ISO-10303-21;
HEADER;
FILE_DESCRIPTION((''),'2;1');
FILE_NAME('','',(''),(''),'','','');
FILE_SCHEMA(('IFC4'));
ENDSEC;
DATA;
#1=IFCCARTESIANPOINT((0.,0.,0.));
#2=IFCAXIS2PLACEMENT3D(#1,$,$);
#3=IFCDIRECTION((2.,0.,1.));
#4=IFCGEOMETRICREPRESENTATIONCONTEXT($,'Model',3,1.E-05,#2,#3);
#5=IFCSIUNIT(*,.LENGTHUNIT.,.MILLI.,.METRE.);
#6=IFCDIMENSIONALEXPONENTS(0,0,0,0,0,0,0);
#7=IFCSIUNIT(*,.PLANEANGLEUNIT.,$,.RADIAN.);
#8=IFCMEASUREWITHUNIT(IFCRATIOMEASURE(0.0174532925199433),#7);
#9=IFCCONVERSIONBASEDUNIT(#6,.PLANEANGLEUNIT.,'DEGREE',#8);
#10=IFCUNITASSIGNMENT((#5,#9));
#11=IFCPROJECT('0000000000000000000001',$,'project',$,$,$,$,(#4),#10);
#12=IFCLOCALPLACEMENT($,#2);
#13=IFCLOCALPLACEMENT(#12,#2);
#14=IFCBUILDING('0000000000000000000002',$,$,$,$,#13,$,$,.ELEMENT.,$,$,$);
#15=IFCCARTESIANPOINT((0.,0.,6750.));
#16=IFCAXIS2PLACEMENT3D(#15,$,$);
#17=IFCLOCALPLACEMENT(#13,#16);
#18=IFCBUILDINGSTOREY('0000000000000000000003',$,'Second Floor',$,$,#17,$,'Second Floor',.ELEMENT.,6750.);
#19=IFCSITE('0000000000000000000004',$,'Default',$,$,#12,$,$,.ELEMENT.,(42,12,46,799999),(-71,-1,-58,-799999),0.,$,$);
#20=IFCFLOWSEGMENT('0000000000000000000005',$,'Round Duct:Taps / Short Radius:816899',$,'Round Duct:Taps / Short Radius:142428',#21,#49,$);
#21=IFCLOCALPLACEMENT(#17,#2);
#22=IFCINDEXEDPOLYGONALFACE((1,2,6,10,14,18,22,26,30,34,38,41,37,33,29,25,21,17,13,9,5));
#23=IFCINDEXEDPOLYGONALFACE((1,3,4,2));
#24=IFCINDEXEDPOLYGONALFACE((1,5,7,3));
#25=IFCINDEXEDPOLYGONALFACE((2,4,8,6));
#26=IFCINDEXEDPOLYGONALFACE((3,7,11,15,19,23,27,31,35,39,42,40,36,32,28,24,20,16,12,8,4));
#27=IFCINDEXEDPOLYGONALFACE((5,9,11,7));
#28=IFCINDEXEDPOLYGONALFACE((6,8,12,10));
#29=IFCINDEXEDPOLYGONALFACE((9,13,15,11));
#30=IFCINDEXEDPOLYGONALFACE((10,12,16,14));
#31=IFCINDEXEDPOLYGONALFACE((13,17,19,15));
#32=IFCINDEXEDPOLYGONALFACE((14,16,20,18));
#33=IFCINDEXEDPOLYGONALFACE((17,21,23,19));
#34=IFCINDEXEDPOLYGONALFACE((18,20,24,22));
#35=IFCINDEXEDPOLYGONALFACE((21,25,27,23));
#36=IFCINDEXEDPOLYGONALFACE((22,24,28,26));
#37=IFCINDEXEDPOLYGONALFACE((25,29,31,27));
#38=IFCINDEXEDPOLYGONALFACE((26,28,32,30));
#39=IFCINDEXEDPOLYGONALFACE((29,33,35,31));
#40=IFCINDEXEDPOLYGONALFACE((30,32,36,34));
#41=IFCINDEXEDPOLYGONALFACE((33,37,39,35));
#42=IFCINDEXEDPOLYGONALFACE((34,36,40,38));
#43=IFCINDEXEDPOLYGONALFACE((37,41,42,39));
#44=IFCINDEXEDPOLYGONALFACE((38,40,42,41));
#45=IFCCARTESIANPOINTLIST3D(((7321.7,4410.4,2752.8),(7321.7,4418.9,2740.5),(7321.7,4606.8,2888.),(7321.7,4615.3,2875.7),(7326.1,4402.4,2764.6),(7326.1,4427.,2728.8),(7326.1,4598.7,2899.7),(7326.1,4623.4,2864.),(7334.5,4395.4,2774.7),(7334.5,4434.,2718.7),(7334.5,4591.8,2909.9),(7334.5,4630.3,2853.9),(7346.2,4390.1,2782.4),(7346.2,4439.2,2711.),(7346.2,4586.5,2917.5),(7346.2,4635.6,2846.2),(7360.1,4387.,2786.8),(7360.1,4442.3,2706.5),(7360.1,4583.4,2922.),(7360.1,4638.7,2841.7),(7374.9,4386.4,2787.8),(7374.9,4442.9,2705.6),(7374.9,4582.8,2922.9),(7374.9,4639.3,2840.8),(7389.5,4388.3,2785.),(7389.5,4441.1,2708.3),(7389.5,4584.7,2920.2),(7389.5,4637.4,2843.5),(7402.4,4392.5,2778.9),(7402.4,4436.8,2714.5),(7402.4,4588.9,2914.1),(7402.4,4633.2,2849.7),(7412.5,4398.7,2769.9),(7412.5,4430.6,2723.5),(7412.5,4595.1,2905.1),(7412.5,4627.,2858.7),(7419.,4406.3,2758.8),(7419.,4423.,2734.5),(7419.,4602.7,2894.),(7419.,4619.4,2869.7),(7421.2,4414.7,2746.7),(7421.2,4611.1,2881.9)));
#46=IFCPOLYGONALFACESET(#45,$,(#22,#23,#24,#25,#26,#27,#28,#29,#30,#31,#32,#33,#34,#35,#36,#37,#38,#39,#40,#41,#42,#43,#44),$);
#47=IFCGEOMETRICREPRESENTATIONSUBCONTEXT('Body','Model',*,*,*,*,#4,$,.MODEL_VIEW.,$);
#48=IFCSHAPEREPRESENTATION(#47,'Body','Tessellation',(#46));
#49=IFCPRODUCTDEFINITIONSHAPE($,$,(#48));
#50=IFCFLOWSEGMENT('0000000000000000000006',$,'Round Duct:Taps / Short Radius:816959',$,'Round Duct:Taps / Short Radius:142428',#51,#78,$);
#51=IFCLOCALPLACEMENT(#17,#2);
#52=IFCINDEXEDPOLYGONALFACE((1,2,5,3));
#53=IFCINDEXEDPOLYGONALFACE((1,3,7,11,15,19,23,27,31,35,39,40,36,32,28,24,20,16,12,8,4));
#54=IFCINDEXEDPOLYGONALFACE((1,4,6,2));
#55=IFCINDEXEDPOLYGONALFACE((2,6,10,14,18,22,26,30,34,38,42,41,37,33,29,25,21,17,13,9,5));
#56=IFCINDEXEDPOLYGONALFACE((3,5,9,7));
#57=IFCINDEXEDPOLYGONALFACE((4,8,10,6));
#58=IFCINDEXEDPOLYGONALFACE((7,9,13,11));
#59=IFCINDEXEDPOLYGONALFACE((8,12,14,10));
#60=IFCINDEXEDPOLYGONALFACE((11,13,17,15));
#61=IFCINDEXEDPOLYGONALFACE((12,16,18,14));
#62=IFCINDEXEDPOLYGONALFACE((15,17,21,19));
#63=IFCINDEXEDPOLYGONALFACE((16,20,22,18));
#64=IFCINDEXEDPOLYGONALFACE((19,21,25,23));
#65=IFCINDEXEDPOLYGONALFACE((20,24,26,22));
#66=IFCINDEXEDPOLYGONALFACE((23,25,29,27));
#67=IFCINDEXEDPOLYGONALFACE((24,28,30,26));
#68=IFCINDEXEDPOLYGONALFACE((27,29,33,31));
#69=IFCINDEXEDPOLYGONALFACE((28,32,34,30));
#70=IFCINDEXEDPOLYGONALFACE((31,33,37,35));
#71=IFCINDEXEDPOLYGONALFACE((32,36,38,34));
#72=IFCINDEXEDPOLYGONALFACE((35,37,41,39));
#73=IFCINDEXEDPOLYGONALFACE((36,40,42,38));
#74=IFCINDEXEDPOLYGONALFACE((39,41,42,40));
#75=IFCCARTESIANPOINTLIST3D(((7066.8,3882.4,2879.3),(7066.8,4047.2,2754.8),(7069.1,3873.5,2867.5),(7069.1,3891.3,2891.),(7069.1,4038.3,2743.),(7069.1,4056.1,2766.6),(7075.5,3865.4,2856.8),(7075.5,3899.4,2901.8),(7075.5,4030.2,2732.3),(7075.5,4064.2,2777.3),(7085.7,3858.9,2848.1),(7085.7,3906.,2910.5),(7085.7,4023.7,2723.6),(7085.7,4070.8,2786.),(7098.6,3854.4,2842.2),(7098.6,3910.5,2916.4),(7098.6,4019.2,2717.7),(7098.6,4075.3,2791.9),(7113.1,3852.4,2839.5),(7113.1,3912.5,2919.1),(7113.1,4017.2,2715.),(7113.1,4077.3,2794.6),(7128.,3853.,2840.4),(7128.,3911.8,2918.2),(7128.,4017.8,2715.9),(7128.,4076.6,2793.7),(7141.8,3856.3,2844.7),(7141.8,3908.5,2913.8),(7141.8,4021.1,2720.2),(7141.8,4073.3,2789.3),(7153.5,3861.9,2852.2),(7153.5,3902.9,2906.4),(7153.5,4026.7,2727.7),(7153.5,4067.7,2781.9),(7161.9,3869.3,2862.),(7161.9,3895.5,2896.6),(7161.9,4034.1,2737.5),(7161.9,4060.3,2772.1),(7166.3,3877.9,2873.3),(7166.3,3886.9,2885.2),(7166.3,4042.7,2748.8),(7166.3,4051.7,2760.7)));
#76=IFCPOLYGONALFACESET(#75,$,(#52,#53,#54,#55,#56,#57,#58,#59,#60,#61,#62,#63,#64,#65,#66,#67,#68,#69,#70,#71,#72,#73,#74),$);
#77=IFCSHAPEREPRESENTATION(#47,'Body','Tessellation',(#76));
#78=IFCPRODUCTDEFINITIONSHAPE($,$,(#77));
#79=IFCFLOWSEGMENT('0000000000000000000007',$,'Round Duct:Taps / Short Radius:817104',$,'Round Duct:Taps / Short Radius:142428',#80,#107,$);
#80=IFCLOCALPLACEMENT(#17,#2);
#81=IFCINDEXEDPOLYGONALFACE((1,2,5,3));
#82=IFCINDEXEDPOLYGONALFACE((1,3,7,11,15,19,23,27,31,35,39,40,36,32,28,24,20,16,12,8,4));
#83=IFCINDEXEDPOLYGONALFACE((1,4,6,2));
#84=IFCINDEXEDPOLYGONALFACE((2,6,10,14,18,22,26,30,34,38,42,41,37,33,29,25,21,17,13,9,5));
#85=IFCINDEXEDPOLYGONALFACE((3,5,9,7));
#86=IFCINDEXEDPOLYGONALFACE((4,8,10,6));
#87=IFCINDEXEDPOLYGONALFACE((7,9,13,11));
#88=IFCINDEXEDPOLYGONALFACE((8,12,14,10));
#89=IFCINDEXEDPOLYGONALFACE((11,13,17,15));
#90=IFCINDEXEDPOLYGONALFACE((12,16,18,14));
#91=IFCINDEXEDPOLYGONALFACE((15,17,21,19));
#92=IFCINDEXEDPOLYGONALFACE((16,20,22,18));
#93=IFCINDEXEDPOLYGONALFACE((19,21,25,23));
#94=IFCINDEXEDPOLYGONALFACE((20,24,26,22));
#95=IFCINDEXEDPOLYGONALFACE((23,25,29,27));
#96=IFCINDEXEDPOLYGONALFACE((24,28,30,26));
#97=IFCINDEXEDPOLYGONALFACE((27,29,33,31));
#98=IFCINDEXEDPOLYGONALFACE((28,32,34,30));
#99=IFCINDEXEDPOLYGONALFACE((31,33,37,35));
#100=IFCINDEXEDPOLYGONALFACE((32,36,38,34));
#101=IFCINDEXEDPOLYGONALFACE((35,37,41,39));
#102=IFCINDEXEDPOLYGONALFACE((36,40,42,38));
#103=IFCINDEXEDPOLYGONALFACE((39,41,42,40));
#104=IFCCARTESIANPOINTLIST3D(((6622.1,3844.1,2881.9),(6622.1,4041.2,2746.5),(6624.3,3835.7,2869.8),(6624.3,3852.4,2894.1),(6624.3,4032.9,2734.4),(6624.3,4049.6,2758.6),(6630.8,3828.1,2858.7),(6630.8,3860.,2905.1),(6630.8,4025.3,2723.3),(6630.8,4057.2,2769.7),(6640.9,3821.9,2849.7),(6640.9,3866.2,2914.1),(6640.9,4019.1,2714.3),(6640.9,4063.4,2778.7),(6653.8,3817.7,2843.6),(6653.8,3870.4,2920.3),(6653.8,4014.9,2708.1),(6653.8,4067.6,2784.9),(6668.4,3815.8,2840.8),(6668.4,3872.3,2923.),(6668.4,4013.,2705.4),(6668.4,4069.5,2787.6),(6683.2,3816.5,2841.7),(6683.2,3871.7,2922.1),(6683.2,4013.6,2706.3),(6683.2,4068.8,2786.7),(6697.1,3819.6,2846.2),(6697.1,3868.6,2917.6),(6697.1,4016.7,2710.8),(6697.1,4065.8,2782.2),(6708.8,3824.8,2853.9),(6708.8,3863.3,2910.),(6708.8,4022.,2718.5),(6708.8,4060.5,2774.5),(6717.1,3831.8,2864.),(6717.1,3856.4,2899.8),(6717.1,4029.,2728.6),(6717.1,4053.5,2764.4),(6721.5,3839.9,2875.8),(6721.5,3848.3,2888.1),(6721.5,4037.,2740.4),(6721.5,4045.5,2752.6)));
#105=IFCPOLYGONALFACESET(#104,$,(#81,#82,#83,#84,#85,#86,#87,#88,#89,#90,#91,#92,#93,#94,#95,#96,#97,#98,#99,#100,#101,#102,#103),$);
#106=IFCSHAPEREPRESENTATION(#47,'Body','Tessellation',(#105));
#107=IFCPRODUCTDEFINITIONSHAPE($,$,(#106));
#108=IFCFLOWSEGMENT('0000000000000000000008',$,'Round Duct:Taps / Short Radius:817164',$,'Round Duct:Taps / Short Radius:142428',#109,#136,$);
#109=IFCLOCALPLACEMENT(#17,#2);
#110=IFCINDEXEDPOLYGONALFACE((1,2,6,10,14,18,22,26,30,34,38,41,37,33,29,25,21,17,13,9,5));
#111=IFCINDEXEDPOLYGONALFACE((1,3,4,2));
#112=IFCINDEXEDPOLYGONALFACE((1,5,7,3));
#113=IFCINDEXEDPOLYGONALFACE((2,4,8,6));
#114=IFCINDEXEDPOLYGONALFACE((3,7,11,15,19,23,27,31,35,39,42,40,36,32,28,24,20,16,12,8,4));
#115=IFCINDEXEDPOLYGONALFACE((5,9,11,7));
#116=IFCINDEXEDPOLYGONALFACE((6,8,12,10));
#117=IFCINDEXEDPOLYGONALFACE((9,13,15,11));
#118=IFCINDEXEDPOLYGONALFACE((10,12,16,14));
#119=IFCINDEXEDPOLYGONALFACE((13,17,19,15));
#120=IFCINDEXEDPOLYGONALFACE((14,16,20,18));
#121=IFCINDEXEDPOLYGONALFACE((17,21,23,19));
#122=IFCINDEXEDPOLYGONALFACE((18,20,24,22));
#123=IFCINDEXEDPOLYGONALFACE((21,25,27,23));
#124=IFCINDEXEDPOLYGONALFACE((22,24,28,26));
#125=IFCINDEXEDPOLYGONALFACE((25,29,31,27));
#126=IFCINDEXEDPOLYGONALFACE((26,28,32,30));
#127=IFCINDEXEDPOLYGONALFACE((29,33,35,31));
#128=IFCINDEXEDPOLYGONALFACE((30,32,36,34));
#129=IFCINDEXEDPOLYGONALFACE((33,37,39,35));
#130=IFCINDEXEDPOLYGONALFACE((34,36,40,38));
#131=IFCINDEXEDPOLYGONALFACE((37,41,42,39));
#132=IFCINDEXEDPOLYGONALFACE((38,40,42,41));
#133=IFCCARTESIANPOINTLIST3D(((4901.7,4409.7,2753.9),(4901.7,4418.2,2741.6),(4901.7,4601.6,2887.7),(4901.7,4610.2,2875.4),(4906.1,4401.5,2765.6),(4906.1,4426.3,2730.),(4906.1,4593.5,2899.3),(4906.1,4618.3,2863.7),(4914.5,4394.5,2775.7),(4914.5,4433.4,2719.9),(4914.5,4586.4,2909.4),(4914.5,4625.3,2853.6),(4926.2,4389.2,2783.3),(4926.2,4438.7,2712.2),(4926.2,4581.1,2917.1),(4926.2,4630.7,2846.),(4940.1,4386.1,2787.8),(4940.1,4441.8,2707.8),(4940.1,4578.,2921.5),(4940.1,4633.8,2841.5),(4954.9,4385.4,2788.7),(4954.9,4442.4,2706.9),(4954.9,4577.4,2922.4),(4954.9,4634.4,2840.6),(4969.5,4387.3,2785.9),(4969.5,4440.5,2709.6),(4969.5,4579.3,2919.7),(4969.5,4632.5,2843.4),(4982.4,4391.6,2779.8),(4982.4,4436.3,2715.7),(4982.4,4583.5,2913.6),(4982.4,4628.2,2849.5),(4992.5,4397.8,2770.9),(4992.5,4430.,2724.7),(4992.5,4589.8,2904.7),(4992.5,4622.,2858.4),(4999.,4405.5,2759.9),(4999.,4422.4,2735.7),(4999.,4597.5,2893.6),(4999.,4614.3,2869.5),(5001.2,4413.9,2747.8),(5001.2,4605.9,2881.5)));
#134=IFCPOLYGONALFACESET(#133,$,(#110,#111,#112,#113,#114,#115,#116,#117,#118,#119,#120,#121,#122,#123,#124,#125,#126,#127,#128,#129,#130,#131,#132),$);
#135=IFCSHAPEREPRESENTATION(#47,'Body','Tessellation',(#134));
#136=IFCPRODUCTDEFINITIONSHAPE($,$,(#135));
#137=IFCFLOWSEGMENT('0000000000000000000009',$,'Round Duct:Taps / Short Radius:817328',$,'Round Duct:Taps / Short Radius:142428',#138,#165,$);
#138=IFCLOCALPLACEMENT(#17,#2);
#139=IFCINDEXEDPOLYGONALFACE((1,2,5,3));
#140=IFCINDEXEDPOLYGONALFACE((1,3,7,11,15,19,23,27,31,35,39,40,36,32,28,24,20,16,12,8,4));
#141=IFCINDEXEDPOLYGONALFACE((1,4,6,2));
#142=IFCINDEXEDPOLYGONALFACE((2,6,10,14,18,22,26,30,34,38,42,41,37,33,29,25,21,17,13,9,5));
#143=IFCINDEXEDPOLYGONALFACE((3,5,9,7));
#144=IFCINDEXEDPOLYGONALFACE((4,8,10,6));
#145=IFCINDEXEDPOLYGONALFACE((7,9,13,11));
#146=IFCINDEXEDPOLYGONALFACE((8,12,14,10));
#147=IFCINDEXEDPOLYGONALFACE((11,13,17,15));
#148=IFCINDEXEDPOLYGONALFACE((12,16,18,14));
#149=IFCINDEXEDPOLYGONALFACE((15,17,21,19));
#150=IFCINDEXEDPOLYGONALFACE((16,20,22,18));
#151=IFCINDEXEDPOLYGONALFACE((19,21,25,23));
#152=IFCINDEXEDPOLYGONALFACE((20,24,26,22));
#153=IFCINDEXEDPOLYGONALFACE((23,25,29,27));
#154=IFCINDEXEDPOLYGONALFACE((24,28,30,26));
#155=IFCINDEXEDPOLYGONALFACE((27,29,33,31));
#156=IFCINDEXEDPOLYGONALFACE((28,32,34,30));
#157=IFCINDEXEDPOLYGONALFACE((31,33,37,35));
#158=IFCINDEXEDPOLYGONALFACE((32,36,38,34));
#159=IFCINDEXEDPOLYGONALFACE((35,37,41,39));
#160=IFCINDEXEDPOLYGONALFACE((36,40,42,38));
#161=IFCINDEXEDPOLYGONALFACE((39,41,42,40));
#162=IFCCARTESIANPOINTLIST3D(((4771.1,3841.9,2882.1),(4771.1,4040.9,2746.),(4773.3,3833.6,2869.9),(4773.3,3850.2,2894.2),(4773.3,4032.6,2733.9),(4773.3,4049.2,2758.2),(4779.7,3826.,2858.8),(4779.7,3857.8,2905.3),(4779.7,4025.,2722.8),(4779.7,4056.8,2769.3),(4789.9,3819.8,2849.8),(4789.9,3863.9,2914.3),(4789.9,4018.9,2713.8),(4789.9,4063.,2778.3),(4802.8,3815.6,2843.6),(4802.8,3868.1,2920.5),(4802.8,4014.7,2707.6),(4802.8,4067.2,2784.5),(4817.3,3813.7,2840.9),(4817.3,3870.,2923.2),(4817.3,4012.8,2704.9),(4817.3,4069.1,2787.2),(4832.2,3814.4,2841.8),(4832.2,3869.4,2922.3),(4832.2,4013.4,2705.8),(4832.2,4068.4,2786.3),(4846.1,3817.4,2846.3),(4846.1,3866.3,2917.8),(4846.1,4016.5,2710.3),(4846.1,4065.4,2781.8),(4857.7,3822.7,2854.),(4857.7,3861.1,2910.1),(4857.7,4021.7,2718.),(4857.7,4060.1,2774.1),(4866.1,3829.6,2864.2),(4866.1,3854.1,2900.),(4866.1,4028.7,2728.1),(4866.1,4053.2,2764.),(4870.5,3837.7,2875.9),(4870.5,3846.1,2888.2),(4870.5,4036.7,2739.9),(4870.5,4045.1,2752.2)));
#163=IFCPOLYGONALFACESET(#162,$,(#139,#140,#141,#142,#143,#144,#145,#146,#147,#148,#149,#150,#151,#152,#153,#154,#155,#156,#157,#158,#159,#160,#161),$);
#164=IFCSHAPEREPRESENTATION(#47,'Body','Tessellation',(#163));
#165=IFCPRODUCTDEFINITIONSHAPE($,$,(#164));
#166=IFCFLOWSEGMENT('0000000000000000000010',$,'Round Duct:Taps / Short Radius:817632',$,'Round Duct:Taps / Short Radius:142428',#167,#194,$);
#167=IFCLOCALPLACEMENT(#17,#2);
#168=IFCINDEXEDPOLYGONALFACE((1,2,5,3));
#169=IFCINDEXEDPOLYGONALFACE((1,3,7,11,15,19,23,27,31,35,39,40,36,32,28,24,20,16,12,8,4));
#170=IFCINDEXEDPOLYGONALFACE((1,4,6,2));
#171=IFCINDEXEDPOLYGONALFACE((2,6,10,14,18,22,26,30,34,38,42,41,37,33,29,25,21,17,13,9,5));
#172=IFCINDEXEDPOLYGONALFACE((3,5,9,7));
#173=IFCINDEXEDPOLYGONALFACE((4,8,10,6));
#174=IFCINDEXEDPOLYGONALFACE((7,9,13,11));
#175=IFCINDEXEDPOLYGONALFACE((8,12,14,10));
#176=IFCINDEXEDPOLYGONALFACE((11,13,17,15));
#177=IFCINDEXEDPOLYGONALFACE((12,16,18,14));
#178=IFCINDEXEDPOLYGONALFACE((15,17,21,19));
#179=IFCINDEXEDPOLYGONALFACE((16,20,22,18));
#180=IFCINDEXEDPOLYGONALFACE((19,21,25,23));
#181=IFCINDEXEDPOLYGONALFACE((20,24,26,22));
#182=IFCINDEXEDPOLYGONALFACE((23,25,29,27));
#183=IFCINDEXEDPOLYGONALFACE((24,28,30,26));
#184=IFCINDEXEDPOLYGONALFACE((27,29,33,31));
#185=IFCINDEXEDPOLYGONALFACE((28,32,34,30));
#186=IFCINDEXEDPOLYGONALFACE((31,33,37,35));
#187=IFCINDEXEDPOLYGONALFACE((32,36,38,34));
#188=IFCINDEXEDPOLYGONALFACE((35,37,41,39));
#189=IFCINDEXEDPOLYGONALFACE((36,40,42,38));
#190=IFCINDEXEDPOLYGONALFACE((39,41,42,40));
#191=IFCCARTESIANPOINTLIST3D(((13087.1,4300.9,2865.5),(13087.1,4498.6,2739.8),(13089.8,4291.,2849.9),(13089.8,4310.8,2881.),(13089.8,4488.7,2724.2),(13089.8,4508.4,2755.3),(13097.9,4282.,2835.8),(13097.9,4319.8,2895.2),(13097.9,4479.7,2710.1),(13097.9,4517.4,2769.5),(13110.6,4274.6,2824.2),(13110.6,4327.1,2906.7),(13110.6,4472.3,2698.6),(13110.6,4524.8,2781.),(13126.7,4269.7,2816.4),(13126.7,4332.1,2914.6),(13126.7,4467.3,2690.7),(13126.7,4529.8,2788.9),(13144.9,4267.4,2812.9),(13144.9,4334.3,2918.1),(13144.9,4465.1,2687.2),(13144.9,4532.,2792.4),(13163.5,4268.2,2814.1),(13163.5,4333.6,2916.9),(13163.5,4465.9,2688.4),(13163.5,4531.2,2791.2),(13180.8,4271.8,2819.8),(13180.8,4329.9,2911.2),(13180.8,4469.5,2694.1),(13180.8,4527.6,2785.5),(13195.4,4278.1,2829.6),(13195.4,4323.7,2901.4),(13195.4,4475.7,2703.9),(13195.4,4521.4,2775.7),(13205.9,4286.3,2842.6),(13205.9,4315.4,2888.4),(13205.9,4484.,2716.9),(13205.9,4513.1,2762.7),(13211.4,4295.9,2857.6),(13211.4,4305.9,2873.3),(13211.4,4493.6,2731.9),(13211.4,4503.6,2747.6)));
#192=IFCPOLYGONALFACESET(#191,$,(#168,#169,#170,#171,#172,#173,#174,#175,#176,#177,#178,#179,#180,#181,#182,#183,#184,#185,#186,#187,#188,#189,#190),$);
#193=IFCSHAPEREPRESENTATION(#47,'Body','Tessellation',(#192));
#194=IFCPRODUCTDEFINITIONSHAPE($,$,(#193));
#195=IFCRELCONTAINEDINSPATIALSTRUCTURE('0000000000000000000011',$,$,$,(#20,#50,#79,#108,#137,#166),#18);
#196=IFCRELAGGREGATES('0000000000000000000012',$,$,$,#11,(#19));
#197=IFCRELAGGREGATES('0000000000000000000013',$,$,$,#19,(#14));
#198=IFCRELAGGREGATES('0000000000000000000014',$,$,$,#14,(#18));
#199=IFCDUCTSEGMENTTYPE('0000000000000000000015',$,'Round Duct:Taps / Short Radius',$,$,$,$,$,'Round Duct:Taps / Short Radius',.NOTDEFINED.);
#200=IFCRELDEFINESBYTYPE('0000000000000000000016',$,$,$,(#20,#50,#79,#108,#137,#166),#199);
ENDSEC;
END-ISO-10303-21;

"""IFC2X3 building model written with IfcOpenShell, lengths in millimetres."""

from ifc_helpers import new_model, entity, si_unit, converted_unit, direction, frame, frame_2d, origin, place, context, subcontext, project, spatial, circle, extrude, type_object, element, save


model = new_model("IFC2X3")

# Units and contexts
model_context = context("Model", 3, precision=1e-05, world=origin(), true_north=direction((2.0, 0.0, 1.0)))
body_context = subcontext(model_context, "Body", "Model", "MODEL_VIEW")
ifc_project = project(units=[si_unit("LENGTHUNIT", "METRE", prefix="MILLI"), converted_unit("PLANEANGLEUNIT", "DEGREE", entity("IfcRatioMeasure", 0.0174532925199433), si_unit("PLANEANGLEUNIT", "RADIAN"), dimensions=[0, 0, 0, 0, 0, 0, 0])], contexts=[model_context])

# Site, building, storey
site_placement = place(None, origin())
site = spatial("IfcSite", under=ifc_project, at=site_placement, Name="Default", CompositionType="ELEMENT", RefLatitude=(42, 12, 46, 799999), RefLongitude=(-71, -1, -58, -799999), RefElevation=0.0)
building_placement = place(site_placement, origin())
building = spatial("IfcBuilding", under=site, at=building_placement, CompositionType="ELEMENT")
storey_placement = place(building_placement, frame((0.0, 0.0, 6750.0)))
storey = spatial("IfcBuildingStorey", under=building, at=storey_placement, Name="Second Floor", LongName="Second Floor", CompositionType="ELEMENT", Elevation=6750.0)

# Flow segments
duct_segment_type = type_object("IfcDuctSegmentType", Name="Round Duct:Taps / Short Radius", ElementType="Round Duct:Taps / Short Radius", PredefinedType="NOTDEFINED")
flow_segment_1_placement = place(storey_placement, origin())
element("IfcFlowSegment", 1, at=flow_segment_1_placement, inside=storey, type_object=duct_segment_type, Name="Round Duct:Taps / Short Radius:816899", ObjectType="Round Duct:Taps / Short Radius:142428", context=body_context, shape_type="SweptSolid", body=[
    extrude(circle(Radius=50.0, at=frame_2d((0.0, 0.0), x_axis=(1.0, 0.0))), frame((7371.2, 4414.7, 2746.7), z_axis=(0.0, 0.823704, 0.56702), x_axis=(1.0, 0.0, 0.0)), (0.0, 0.0, 1.0), 238.4),
])
flow_segment_2_placement = place(storey_placement, origin())
element("IfcFlowSegment", 2, at=flow_segment_2_placement, inside=storey, type_object=duct_segment_type, Name="Round Duct:Taps / Short Radius:816959", ObjectType="Round Duct:Taps / Short Radius:142428", context=body_context, shape_type="SweptSolid", body=[
    extrude(circle(Radius=50.0, at=frame_2d((0.0, 0.0), x_axis=(1.0, 0.0))), frame((7116.8, 3882.4, 2879.3), z_axis=(0.0, 0.797896, -0.602795), x_axis=(-1.0, 0.0, 0.0)), (0.0, 0.0, 1.0), 206.5),
])
flow_segment_3_placement = place(storey_placement, origin())
element("IfcFlowSegment", 3, at=flow_segment_3_placement, inside=storey, type_object=duct_segment_type, Name="Round Duct:Taps / Short Radius:817104", ObjectType="Round Duct:Taps / Short Radius:142428", context=body_context, shape_type="SweptSolid", body=[
    extrude(circle(Radius=50.0, at=frame_2d((0.0, 0.0), x_axis=(1.0, 0.0))), frame((6672.1, 4041.2, 2746.5), z_axis=(0.0, -0.824276, 0.566188), x_axis=(-1.0, 0.0, 0.0)), (0.0, 0.0, 1.0), 239.2),
])
flow_segment_4_placement = place(storey_placement, origin())
element("IfcFlowSegment", 4, at=flow_segment_4_placement, inside=storey, type_object=duct_segment_type, Name="Round Duct:Taps / Short Radius:817164", ObjectType="Round Duct:Taps / Short Radius:142428", context=body_context, shape_type="SweptSolid", body=[
    extrude(circle(Radius=50.0, at=frame_2d((0.0, 0.0), x_axis=(1.0, 0.0))), frame((4951.2, 4413.9, 2747.8), z_axis=(0.0, 0.820423, 0.571757), x_axis=(1.0, 0.0, 0.0)), (0.0, 0.0, 1.0), 234.0),
])
flow_segment_5_placement = place(storey_placement, origin())
element("IfcFlowSegment", 5, at=flow_segment_5_placement, inside=storey, type_object=duct_segment_type, Name="Round Duct:Taps / Short Radius:817328", ObjectType="Round Duct:Taps / Short Radius:142428", context=body_context, shape_type="SweptSolid", body=[
    extrude(circle(Radius=50.0, at=frame_2d((0.0, 0.0), x_axis=(1.0, 0.0))), frame((4821.1, 4040.9, 2746.0), z_axis=(0.0, -0.82565, 0.564183), x_axis=(-1.0, 0.0, 0.0)), (0.0, 0.0, 1.0), 241.1),
])
flow_segment_6_placement = place(storey_placement, origin())
element("IfcFlowSegment", 6, at=flow_segment_6_placement, inside=storey, type_object=duct_segment_type, Name="Round Duct:Taps / Short Radius:817632", ObjectType="Round Duct:Taps / Short Radius:142428", context=body_context, shape_type="SweptSolid", body=[
    extrude(circle(Radius=62.5, at=frame_2d((0.0, 0.0), x_axis=(1.0, 0.0))), frame((13149.6, 4300.9, 2865.5), z_axis=(0.0, 0.84386, -0.536563), x_axis=(-1.0, 0.0, 0.0)), (0.0, 0.0, 1.0), 234.3),
])

save(model, "model.ifc")
